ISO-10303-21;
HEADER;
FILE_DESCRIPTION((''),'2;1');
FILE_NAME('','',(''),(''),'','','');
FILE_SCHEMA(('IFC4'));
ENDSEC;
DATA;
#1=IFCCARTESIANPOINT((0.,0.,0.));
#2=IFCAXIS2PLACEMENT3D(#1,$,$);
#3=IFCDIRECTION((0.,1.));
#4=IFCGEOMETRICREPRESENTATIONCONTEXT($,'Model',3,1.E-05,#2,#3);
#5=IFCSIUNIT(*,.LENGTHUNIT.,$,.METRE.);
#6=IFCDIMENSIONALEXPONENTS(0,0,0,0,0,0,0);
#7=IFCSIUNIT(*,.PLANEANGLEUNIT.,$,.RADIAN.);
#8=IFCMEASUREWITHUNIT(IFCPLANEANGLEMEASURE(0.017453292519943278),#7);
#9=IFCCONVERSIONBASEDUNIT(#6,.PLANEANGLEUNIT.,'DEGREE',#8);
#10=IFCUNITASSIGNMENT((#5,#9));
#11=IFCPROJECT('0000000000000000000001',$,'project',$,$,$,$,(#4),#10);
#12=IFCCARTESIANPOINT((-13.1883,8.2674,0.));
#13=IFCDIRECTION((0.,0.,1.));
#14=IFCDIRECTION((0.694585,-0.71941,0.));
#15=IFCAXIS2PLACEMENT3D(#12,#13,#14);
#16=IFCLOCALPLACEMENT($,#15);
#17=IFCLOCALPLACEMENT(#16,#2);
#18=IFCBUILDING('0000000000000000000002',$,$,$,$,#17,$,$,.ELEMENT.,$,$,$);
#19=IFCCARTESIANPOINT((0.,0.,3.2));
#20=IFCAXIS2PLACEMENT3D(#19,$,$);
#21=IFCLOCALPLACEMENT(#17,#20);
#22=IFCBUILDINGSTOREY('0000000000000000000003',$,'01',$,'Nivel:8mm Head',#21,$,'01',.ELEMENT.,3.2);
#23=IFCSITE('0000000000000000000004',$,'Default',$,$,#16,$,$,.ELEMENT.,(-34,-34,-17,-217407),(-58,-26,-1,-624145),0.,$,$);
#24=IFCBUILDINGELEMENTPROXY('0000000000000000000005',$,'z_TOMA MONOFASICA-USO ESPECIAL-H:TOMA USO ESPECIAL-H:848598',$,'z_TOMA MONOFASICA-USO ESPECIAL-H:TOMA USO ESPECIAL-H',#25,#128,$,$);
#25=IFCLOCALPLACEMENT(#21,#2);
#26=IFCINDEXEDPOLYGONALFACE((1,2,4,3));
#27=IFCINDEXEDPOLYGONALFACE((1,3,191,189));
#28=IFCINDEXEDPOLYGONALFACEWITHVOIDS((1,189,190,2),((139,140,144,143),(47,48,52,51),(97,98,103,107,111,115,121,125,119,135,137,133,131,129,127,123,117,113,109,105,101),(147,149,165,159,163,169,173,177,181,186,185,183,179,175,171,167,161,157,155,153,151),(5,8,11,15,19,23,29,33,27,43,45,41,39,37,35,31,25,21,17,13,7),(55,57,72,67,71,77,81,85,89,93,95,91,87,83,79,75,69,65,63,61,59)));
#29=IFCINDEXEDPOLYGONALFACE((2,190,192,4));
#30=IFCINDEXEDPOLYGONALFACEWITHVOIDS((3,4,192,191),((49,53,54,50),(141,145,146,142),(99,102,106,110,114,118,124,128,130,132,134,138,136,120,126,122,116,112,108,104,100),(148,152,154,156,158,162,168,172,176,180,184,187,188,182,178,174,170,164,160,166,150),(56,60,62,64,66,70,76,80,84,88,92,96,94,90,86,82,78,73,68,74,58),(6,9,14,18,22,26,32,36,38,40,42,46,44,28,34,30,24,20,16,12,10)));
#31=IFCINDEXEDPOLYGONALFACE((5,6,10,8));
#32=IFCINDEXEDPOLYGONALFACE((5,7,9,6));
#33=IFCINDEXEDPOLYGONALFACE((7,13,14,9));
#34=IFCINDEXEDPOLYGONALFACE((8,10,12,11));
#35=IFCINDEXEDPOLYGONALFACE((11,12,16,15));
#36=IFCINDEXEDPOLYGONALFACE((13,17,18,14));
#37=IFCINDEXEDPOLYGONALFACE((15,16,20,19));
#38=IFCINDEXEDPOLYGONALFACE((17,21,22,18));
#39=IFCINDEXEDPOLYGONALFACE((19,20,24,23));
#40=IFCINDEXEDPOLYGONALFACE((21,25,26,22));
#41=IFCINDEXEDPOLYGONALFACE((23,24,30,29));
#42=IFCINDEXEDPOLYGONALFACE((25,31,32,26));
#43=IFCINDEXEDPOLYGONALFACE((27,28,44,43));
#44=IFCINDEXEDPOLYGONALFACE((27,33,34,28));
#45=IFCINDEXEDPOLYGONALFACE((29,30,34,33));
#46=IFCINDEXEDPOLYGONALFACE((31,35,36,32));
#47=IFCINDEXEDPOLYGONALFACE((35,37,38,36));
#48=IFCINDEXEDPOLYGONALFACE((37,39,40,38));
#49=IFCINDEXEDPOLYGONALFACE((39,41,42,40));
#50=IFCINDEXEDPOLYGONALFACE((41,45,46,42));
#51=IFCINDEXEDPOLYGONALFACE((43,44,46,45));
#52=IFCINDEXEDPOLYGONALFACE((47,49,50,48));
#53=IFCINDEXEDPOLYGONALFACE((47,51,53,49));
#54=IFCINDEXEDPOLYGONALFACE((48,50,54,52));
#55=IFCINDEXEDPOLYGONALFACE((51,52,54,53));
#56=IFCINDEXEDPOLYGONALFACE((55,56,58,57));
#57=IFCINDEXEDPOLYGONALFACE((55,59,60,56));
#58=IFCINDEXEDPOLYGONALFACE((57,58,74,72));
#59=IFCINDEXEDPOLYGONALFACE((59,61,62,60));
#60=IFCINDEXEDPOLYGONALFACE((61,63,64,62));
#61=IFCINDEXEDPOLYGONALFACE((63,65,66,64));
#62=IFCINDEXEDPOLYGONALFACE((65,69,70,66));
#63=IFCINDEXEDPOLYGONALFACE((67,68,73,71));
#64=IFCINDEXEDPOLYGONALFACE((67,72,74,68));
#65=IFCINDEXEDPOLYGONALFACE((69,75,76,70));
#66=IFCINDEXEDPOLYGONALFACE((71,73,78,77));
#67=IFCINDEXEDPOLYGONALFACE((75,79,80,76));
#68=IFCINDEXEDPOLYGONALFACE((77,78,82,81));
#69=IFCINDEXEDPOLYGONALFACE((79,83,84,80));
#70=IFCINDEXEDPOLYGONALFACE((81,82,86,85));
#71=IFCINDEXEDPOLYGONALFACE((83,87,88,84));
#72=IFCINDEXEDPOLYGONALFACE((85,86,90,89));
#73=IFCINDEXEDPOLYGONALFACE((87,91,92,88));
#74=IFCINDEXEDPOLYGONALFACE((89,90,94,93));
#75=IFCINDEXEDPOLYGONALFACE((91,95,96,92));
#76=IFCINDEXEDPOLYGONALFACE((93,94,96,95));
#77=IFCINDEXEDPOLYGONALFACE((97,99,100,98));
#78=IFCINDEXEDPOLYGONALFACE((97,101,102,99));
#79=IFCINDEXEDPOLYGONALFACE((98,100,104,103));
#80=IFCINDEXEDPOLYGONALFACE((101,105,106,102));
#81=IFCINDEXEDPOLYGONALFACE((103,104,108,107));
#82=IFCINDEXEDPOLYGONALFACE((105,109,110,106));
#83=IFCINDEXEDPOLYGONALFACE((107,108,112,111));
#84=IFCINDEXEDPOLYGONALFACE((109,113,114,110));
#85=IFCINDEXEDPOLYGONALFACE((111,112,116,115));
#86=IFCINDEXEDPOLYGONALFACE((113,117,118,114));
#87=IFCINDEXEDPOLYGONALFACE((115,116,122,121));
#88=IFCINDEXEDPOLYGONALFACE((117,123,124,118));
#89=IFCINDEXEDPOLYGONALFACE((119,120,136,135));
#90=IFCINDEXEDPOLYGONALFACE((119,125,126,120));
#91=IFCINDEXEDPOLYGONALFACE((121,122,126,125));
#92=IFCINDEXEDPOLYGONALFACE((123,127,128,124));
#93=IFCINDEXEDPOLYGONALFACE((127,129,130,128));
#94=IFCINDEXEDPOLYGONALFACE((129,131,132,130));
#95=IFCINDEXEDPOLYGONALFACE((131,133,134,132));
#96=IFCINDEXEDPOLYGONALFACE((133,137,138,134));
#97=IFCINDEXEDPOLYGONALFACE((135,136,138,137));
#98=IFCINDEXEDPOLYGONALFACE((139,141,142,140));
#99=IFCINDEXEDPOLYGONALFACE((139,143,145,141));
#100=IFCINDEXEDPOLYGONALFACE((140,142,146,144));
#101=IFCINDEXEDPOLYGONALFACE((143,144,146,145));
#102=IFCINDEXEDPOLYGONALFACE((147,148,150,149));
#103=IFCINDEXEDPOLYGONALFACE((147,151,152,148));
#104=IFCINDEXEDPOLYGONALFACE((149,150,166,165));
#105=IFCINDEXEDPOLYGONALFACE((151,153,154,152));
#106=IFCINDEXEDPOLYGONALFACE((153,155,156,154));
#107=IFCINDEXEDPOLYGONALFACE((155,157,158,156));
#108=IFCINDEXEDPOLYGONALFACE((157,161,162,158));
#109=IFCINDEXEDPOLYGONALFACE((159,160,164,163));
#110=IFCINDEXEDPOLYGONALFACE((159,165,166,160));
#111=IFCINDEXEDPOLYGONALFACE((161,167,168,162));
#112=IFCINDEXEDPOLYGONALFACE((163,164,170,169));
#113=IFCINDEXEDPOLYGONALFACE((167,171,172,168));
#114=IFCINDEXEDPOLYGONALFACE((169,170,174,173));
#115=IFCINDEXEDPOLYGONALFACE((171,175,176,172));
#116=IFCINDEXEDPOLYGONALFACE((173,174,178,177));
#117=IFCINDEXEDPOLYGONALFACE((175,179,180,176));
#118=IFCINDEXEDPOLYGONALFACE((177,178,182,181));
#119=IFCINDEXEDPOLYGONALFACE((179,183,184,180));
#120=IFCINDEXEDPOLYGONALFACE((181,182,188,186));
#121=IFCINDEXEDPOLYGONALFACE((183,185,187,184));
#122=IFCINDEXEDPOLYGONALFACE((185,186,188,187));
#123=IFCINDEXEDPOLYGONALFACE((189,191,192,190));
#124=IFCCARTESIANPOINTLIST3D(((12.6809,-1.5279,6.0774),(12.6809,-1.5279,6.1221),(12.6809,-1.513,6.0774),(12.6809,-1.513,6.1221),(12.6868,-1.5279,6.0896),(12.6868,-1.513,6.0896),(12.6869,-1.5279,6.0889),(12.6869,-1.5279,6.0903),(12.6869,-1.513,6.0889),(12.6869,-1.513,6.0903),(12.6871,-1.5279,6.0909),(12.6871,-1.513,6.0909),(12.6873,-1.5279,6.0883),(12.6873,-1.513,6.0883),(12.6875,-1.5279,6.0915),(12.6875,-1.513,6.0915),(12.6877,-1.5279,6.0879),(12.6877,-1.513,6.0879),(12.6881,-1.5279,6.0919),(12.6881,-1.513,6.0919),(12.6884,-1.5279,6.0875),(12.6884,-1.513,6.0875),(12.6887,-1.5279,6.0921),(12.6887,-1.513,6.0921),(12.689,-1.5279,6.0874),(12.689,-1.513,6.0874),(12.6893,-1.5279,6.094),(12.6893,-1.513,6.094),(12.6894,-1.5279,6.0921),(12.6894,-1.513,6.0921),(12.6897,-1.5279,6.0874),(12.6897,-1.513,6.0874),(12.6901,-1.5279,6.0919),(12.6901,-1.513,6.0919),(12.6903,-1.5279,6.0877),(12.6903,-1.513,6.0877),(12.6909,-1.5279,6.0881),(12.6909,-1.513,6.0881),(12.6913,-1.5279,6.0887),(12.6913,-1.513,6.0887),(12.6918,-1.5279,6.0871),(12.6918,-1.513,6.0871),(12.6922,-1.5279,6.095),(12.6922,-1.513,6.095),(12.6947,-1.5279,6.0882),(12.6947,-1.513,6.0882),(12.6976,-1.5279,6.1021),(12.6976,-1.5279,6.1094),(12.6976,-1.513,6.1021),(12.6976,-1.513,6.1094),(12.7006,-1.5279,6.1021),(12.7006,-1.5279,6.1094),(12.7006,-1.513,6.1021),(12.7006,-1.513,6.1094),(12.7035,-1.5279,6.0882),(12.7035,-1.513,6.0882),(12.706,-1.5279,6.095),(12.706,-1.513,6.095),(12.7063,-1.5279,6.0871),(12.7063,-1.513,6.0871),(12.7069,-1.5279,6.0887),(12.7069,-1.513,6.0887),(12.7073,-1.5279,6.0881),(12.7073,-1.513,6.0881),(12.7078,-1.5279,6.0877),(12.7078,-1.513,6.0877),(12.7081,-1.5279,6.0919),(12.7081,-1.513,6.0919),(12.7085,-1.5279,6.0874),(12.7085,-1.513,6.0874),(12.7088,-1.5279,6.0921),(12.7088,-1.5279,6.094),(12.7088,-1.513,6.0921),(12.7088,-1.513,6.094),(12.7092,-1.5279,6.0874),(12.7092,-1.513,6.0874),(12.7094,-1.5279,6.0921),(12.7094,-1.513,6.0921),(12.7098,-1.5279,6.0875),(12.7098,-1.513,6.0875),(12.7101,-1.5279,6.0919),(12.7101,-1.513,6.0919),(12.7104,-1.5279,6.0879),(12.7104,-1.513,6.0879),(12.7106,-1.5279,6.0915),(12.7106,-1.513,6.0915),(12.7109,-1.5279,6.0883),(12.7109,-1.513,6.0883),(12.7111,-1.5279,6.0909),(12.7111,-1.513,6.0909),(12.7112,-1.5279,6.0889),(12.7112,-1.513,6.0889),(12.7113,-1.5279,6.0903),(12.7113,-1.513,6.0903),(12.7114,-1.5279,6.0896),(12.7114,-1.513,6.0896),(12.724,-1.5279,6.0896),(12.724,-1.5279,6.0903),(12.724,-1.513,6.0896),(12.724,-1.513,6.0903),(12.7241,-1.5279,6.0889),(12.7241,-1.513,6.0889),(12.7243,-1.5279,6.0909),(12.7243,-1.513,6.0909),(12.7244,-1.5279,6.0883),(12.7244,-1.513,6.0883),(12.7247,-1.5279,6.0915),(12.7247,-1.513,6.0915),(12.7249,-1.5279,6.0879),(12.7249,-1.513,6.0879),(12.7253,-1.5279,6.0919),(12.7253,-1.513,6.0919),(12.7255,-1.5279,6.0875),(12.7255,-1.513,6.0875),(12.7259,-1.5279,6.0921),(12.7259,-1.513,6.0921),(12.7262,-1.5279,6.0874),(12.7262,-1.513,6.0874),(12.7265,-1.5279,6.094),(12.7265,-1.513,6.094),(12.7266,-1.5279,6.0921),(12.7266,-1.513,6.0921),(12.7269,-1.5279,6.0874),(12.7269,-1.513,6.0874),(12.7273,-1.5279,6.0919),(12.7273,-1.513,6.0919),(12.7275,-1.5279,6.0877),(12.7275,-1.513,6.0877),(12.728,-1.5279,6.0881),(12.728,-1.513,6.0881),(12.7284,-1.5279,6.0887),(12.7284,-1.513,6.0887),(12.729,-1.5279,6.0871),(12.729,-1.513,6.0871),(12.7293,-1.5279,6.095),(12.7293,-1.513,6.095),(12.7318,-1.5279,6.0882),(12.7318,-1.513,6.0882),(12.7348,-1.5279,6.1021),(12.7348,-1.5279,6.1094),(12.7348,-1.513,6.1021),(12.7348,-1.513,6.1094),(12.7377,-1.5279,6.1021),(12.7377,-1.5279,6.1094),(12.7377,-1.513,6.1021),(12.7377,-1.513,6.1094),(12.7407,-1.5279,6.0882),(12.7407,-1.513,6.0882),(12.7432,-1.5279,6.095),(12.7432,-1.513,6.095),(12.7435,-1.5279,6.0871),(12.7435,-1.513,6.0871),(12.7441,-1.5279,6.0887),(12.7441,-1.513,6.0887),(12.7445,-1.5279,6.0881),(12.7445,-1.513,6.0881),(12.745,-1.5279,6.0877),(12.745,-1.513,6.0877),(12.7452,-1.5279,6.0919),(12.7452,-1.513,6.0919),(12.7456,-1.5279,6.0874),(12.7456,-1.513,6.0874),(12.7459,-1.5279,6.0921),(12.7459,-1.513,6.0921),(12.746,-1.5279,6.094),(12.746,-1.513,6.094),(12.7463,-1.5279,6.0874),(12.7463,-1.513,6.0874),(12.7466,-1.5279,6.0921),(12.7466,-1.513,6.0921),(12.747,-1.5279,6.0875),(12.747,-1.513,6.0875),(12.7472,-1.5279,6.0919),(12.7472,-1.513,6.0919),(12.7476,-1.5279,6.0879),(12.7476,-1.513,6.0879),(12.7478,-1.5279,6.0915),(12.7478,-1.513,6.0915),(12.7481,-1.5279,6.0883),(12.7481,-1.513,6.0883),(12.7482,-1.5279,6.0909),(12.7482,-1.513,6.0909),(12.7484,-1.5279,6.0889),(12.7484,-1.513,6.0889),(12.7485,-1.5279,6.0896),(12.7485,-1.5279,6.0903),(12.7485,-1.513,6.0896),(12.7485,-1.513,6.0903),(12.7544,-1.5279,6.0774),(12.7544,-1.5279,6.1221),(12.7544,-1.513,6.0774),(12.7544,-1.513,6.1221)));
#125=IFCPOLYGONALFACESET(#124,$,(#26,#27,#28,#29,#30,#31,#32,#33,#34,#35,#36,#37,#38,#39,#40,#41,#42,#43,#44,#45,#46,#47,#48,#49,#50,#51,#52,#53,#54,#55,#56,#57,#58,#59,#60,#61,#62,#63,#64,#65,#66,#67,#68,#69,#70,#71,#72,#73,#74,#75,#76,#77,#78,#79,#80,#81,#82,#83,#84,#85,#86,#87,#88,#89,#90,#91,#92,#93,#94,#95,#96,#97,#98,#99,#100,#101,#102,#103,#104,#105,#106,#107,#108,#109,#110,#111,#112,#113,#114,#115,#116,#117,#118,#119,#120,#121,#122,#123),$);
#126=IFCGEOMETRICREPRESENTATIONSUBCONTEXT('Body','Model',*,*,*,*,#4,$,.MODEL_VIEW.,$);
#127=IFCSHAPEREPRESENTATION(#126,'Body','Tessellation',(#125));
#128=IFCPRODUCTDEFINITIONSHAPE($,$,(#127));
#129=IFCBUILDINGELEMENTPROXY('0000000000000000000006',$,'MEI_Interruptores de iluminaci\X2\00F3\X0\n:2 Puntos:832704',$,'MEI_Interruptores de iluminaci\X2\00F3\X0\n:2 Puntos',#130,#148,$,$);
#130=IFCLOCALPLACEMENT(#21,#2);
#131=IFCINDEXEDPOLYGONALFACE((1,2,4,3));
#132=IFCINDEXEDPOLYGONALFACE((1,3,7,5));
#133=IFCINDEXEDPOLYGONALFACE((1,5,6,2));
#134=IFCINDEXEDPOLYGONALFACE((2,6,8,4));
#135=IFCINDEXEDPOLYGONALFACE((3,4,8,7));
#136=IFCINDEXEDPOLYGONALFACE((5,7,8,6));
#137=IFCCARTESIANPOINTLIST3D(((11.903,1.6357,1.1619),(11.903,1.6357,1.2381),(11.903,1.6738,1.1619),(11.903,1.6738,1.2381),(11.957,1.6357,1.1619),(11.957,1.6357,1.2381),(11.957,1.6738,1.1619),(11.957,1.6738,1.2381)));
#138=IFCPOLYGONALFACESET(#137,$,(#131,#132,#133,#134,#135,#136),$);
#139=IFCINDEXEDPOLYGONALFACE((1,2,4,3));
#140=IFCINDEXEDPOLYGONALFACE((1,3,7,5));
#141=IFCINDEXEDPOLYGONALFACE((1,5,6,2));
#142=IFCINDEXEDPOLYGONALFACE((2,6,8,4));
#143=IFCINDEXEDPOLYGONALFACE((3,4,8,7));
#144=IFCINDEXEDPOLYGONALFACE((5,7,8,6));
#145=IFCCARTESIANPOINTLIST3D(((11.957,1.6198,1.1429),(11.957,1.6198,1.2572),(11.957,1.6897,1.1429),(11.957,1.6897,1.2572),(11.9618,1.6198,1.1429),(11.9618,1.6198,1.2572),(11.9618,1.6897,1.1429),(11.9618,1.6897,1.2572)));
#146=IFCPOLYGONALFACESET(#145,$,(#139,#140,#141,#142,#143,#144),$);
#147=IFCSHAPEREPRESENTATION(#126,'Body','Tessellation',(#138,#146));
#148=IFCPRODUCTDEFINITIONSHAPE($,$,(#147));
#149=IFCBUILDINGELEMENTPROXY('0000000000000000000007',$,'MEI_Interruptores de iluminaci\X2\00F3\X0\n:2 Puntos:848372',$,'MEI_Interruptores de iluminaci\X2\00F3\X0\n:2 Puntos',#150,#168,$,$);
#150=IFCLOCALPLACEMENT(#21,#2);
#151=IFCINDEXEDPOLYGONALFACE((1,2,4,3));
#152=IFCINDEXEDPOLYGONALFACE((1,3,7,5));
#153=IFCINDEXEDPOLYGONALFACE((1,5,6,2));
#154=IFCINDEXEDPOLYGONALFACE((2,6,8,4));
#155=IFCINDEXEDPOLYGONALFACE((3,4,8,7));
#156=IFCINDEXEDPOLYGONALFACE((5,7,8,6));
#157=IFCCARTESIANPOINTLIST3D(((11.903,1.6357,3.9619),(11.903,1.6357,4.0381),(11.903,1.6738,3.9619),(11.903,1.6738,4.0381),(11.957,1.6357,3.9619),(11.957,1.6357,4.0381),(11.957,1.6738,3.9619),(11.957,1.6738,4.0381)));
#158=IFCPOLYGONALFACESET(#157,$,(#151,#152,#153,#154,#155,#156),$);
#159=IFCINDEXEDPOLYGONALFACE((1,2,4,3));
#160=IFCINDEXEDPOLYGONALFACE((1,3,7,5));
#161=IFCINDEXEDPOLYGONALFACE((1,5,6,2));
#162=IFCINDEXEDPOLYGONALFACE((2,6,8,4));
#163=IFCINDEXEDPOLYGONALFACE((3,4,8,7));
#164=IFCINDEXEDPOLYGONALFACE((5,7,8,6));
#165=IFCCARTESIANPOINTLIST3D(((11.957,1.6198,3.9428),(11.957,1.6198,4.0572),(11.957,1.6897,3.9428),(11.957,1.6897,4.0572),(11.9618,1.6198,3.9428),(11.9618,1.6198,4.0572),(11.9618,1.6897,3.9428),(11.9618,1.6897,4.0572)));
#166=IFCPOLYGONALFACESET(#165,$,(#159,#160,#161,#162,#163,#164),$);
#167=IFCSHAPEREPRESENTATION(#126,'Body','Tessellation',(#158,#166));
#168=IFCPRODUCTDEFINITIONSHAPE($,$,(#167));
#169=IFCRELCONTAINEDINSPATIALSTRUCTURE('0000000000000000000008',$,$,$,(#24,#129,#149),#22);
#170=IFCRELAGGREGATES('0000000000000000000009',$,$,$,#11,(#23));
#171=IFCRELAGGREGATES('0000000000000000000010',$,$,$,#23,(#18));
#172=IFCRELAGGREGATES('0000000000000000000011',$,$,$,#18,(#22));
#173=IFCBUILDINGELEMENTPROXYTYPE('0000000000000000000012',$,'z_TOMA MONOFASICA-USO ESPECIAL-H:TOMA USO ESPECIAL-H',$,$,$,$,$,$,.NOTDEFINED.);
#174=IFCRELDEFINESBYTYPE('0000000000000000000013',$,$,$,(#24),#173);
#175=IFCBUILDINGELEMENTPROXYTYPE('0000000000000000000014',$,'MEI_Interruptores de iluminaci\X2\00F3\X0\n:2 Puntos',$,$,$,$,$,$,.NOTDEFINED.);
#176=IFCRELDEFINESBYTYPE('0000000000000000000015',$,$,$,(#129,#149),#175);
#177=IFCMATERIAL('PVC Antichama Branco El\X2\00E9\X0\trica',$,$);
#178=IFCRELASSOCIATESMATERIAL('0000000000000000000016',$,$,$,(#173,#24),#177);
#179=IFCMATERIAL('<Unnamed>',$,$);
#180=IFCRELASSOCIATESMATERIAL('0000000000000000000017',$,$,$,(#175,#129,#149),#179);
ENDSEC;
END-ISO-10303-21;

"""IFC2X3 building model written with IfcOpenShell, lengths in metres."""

from ifc_helpers import new_model, entity, si_unit, converted_unit, direction, frame, frame_2d, origin, origin_2d_with_axis, place, context, subcontext, project, spatial, polyline, circle_curve, parameter, trimmed, segment, composite_curve, rectangle, outline, extrude, source, transform, mapped, material, type_object, type_shapes, element, save


model = new_model("IFC2X3")

# Units and contexts
model_context = context("Model", 3, precision=1e-05, world=origin(), true_north=direction((0.0, 1.0)))
body_context = subcontext(model_context, "Body", "Model", "MODEL_VIEW")
ifc_project = project(units=[si_unit("LENGTHUNIT", "METRE"), converted_unit("PLANEANGLEUNIT", "DEGREE", entity("IfcPlaneAngleMeasure", 0.017453292519943278), si_unit("PLANEANGLEUNIT", "RADIAN"), dimensions=[0, 0, 0, 0, 0, 0, 0])], contexts=[model_context])

# Site, building, storey
site_placement = place(None, frame((-13.1883, 8.2674, 0.0), z_axis=(0.0, 0.0, 1.0), x_axis=(0.694585, -0.71941, 0.0)))
site = spatial("IfcSite", under=ifc_project, at=site_placement, Name="Default", CompositionType="ELEMENT", RefLatitude=(-34, -34, -17, -217407), RefLongitude=(-58, -26, -1, -624145), RefElevation=0.0)
building_placement = place(site_placement, origin())
building = spatial("IfcBuilding", under=site, at=building_placement, CompositionType="ELEMENT")
storey_placement = place(building_placement, frame((0.0, 0.0, 3.2)))
storey = spatial("IfcBuildingStorey", under=building, at=storey_placement, Name="01", ObjectType="Nivel:8mm Head", LongName="01", CompositionType="ELEMENT", Elevation=3.2)

# Building element proxies
ifc_material_1 = material(Name="PVC Antichama Branco Elétrica")
building_element_proxy_type_1 = type_object("IfcBuildingElementProxyType", Name="z_TOMA MONOFASICA-USO ESPECIAL-H:TOMA USO ESPECIAL-H", PredefinedType="NOTDEFINED", material=ifc_material_1)
shared_shape_1 = source(origin(), body_context, "Body", "SweptSolid", [
    extrude(outline(polyline([(-0.0368, -0.0223), (0.0368, -0.0223), (0.0368, 0.0223), (-0.0368, 0.0223), (-0.0368, -0.0223)]), holes=[composite_curve([segment(polyline([(0.0141, 0.0115), (0.0116, 0.0047)]), True, "CONTINUOUS"), segment(polyline([(0.0116, 0.0047), (0.0088, 0.0057)]), True, "CONTINUOUS"), segment(polyline([(0.0088, 0.0057), (0.0096, 0.0078)]), True, "CONTINUOUS"), segment(trimmed(circle_curve(frame_2d((0.0087, 0.0099), x_axis=(1.0, 0.0)), 0.0024), [parameter(27.118901)], [parameter(292.881099)], True, "PARAMETER"), False, "CONTINUOUS"), segment(polyline([(0.0108, 0.011), (0.0113, 0.0126)]), True, "CONTINUOUS"), segment(polyline([(0.0113, 0.0126), (0.0141, 0.0115)]), True, "CONTINUOUS")], self_intersect=False), composite_curve([segment(polyline([(0.0255, 0.0047), (0.023, 0.0115)]), True, "CONTINUOUS"), segment(polyline([(0.023, 0.0115), (0.0258, 0.0126)]), True, "CONTINUOUS"), segment(polyline([(0.0258, 0.0126), (0.0264, 0.011)]), True, "CONTINUOUS"), segment(trimmed(circle_curve(frame_2d((0.0285, 0.0099), x_axis=(1.0, 0.0)), 0.0024), [parameter(247.118901)], [parameter(152.881099)], True, "PARAMETER"), False, "CONTINUOUS"), segment(polyline([(0.0276, 0.0078), (0.0283, 0.0057)]), True, "CONTINUOUS"), segment(polyline([(0.0283, 0.0057), (0.0255, 0.0047)]), True, "CONTINUOUS")], self_intersect=False), polyline([(0.0201, -0.0024), (0.0201, -0.0097), (0.0171, -0.0097), (0.0171, -0.0024), (0.0201, -0.0024)]), composite_curve([segment(polyline([(-0.0141, 0.0115), (-0.0113, 0.0126)]), True, "CONTINUOUS"), segment(polyline([(-0.0113, 0.0126), (-0.0108, 0.011)]), True, "CONTINUOUS"), segment(trimmed(circle_curve(frame_2d((-0.0087, 0.0099), x_axis=(1.0, 0.0)), 0.0024), [parameter(247.118901)], [parameter(152.881099)], True, "PARAMETER"), False, "CONTINUOUS"), segment(polyline([(-0.0096, 0.0078), (-0.0088, 0.0057)]), True, "CONTINUOUS"), segment(polyline([(-0.0088, 0.0057), (-0.0116, 0.0047)]), True, "CONTINUOUS"), segment(polyline([(-0.0116, 0.0047), (-0.0141, 0.0115)]), True, "CONTINUOUS")], self_intersect=False), composite_curve([segment(polyline([(-0.0255, 0.0047), (-0.0283, 0.0057)]), True, "CONTINUOUS"), segment(polyline([(-0.0283, 0.0057), (-0.0276, 0.0078)]), True, "CONTINUOUS"), segment(trimmed(circle_curve(frame_2d((-0.0285, 0.0099), x_axis=(1.0, 0.0)), 0.0024), [parameter(27.118901)], [parameter(292.881099)], True, "PARAMETER"), False, "CONTINUOUS"), segment(polyline([(-0.0264, 0.011), (-0.0258, 0.0126)]), True, "CONTINUOUS"), segment(polyline([(-0.0258, 0.0126), (-0.023, 0.0115)]), True, "CONTINUOUS"), segment(polyline([(-0.023, 0.0115), (-0.0255, 0.0047)]), True, "CONTINUOUS")], self_intersect=False), polyline([(-0.0201, -0.0024), (-0.0171, -0.0024), (-0.0171, -0.0097), (-0.0201, -0.0097), (-0.0201, -0.0024)])]), frame((0.0, -0.005, 0.0223), z_axis=(0.0, 1.0, 0.0), x_axis=(1.0, 0.0, 0.0)), (0.0, 0.0, 1.0), 0.0148),
])
type_shapes(building_element_proxy_type_1, [shared_shape_1])
for number, where, name in (
    (1, (12.7177, -1.5229, 6.0774), "z_TOMA MONOFASICA-USO ESPECIAL-H:TOMA USO ESPECIAL-H:848598"),
):
    element("IfcBuildingElementProxy", number, at=place(storey_placement, frame(where)), inside=storey, type_object=building_element_proxy_type_1, material=ifc_material_1, Name=name, ObjectType="z_TOMA MONOFASICA-USO ESPECIAL-H:TOMA USO ESPECIAL-H", context=body_context, shape_type="MappedRepresentation", body=[
        mapped(shared_shape_1, transform((0.0, 0.0, 0.0), scale=1.0)),
    ])
ifc_material_2 = material(Name="<Unnamed>")
building_element_proxy_type_2 = type_object("IfcBuildingElementProxyType", Name="MEI_Interruptores de iluminación:2 Puntos", PredefinedType="NOTDEFINED", material=ifc_material_2)
shared_shape_2 = source(origin(), body_context, "Body", "SweptSolid", [
    extrude(rectangle(XDim=0.0381, YDim=0.0762, at=origin_2d_with_axis()), frame((0.0, 0.0, -0.054), z_axis=(0.0, 0.0, 1.0), x_axis=(-1.0, 0.0, 0.0)), (0.0, 0.0, 1.0), 0.054),
    extrude(rectangle(XDim=0.0698, YDim=0.1143, at=frame_2d((0.0, 0.0), x_axis=(1.0, 0.0))), frame((0.0, 0.0, 0.0), z_axis=(0.0, 0.0, 1.0), x_axis=(-1.0, 0.0, 0.0)), (0.0, 0.0, 1.0), 0.0048),
])
type_shapes(building_element_proxy_type_2, [shared_shape_2])
for number, where, z_axis, x_axis, name in (
    (2, (11.957, 1.6547, 1.2), (1.0, 0.0, 0.0), (0.0, 1.0, 0.0), "MEI_Interruptores de iluminación:2 Puntos:832704"),
    (3, (11.957, 1.6547, 4.0), (1.0, 0.0, 0.0), (0.0, 1.0, 0.0), "MEI_Interruptores de iluminación:2 Puntos:848372"),
):
    element("IfcBuildingElementProxy", number, at=place(storey_placement, frame(where, z_axis=z_axis, x_axis=x_axis)), inside=storey, type_object=building_element_proxy_type_2, material=ifc_material_2, Name=name, ObjectType="MEI_Interruptores de iluminación:2 Puntos", context=body_context, shape_type="MappedRepresentation", body=[
        mapped(shared_shape_2, transform((0.0, 0.0, 0.0), scale=1.0)),
    ])

save(model, "model.ifc")
